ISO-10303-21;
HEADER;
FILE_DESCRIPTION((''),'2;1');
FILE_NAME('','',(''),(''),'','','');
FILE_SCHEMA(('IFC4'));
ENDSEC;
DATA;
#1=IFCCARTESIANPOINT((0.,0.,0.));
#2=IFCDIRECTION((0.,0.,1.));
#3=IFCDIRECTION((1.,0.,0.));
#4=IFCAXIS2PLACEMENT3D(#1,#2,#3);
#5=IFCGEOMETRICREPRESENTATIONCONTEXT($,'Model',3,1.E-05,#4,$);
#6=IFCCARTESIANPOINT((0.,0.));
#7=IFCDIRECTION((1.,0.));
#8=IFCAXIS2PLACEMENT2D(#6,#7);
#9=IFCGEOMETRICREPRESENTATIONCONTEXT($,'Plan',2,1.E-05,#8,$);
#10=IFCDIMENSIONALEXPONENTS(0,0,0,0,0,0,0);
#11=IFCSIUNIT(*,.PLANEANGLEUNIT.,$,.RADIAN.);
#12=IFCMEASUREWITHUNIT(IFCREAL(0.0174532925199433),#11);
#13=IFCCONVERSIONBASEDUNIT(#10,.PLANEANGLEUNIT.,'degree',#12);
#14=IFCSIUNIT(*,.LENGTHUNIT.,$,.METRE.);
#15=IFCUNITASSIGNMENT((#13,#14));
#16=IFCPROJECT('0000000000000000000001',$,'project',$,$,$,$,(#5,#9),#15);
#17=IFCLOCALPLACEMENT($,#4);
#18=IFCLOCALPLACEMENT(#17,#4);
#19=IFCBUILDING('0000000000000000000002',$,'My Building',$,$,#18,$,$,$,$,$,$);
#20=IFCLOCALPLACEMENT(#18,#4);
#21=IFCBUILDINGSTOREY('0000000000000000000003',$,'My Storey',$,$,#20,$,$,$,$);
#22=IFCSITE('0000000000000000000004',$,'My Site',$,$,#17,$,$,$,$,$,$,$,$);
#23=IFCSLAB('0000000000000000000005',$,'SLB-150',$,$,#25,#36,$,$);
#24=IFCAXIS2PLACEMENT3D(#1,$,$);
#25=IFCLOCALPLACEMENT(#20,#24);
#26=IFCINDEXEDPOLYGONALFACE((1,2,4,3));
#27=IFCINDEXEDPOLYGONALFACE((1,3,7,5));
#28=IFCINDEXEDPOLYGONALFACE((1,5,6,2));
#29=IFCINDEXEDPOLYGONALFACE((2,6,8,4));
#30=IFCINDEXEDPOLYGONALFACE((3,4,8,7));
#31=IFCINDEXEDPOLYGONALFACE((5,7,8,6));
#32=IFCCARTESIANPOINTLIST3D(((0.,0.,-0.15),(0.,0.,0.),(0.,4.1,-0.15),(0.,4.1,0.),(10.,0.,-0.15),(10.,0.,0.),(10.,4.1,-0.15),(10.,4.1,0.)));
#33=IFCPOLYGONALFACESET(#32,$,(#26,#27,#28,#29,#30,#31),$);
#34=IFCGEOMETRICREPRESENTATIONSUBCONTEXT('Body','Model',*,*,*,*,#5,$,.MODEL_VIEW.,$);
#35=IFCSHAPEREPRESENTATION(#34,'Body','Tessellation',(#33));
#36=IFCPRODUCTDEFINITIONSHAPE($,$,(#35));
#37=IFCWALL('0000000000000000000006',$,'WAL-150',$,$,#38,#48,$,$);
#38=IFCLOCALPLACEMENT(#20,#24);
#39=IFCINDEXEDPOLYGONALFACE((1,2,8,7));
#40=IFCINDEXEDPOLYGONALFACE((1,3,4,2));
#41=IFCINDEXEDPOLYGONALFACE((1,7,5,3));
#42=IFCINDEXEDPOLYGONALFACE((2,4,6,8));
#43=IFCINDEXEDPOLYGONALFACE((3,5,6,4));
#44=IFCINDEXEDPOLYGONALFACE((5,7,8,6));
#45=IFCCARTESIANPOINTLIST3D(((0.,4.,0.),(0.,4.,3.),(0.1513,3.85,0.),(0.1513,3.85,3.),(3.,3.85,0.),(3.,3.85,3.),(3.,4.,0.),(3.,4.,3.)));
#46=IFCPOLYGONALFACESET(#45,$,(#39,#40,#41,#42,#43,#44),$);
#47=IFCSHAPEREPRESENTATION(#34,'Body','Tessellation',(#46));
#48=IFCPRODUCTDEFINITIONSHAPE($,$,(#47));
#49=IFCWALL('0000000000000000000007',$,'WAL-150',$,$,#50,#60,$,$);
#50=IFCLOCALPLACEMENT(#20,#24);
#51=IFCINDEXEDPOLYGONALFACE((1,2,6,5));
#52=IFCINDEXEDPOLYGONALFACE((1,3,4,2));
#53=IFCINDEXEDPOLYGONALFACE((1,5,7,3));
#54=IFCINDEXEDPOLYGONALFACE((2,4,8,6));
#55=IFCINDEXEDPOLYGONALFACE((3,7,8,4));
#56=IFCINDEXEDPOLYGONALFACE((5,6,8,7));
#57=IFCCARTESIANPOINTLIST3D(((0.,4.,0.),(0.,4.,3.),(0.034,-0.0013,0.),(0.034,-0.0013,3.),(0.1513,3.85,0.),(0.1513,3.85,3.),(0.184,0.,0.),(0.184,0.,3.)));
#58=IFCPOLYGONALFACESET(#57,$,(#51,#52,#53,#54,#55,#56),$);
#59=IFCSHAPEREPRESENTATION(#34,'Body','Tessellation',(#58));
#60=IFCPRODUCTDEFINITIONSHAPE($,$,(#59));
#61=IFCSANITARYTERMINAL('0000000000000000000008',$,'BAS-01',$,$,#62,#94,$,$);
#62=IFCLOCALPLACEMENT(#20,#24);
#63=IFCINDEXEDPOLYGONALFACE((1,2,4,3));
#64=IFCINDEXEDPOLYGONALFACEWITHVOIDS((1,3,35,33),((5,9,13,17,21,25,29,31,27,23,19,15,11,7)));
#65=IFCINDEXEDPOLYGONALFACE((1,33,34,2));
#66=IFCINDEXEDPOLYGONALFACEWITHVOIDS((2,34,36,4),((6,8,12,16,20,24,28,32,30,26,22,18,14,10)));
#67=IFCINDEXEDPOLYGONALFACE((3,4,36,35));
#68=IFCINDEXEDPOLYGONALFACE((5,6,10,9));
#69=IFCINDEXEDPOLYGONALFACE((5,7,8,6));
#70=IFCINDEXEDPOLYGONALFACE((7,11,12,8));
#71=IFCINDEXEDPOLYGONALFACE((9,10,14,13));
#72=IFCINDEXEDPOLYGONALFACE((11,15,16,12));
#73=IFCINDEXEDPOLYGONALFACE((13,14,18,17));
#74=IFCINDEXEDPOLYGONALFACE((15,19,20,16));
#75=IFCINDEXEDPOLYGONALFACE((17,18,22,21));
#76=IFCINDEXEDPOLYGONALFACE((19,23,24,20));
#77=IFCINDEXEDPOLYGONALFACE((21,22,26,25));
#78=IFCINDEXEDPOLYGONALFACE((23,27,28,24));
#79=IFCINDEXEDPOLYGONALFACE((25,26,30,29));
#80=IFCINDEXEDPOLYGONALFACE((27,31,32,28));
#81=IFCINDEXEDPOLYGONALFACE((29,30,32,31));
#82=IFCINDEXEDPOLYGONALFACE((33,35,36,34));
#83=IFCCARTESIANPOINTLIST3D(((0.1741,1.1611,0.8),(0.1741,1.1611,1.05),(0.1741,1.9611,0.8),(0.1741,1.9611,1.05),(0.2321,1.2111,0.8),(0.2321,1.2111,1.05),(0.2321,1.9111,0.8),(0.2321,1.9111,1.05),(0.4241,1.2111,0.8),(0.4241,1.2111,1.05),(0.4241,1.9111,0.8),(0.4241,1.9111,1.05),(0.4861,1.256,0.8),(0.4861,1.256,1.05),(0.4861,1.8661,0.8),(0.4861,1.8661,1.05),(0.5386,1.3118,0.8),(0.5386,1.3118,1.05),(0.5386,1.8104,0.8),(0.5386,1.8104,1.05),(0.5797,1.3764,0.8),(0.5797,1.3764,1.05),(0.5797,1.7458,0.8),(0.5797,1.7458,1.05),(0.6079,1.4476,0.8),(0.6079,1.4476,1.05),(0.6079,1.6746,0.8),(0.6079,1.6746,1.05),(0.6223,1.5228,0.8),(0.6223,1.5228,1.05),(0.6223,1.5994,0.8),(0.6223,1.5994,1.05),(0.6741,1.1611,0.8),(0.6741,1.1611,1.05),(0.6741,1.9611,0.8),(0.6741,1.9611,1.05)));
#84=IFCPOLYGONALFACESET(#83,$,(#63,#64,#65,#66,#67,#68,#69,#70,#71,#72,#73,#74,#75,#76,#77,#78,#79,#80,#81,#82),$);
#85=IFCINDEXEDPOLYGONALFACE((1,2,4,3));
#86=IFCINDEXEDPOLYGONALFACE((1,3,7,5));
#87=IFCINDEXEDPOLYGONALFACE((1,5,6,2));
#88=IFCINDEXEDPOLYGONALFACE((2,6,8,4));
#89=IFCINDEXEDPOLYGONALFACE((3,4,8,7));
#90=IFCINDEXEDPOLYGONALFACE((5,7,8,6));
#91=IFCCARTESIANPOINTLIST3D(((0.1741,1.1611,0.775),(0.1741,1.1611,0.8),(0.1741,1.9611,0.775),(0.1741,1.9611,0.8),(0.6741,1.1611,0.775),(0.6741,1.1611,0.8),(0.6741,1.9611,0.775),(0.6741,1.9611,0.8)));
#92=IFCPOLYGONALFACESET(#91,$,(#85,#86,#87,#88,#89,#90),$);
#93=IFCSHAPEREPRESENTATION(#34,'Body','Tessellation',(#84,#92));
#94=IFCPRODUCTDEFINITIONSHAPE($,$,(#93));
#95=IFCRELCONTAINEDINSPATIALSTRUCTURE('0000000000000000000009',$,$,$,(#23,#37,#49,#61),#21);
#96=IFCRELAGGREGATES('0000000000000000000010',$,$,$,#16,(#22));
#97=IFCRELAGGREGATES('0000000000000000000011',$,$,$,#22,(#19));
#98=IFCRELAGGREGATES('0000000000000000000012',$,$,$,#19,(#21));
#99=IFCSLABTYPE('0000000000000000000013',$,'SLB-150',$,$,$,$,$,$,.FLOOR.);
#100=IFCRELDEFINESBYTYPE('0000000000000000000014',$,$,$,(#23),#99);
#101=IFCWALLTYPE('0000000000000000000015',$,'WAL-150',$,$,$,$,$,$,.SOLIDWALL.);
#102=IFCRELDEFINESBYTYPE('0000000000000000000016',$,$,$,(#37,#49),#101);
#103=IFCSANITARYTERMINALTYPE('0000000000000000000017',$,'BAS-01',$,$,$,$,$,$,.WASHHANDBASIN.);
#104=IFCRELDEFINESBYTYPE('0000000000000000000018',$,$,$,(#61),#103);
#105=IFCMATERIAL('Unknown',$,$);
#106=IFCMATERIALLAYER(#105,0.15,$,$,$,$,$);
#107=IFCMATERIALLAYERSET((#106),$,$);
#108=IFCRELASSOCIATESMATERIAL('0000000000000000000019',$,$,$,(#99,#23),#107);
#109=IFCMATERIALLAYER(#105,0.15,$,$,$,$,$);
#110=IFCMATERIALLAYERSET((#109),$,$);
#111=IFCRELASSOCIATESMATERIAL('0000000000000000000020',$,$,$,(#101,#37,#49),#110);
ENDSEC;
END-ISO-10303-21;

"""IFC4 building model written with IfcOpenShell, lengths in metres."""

from ifc_helpers import new_model, entity, si_unit, converted_unit, frame, origin_with_axes, origin_2d_with_axis, place, context, subcontext, project, spatial, line, arc, indexed_curve, outline, extrude, source, transform, mapped, material, layer, layer_set, layer_usage, type_object, type_shapes, element, save


model = new_model("IFC4")

# Units and contexts
model_context = context("Model", 3, precision=1e-05, world=origin_with_axes())
plan_context = context("Plan", 2, precision=1e-05, world=origin_2d_with_axis())
body_context = subcontext(model_context, "Body", "Model", "MODEL_VIEW")
ifc_project = project(units=[converted_unit("PLANEANGLEUNIT", "degree", entity("IfcReal", 0.0174532925199433), si_unit("PLANEANGLEUNIT", "RADIAN"), dimensions=[0, 0, 0, 0, 0, 0, 0]), si_unit("LENGTHUNIT", "METRE")], contexts=[model_context, plan_context])

# Site, building, storey
site_placement = place(None, origin_with_axes())
site = spatial("IfcSite", under=ifc_project, at=site_placement, Name="My Site")
building_placement = place(site_placement, origin_with_axes())
building = spatial("IfcBuilding", under=site, at=building_placement, Name="My Building")
storey_placement = place(building_placement, origin_with_axes())
storey = spatial("IfcBuildingStorey", under=building, at=storey_placement, Name="My Storey")

# Slab
ifc_material_1 = material(Name="Unknown")
ifc_layer_1 = layer(ifc_material_1, 0.15)
ifc_layer_set_1 = layer_set([ifc_layer_1])
ifc_layer_usage_1 = layer_usage(ifc_layer_set_1, "AXIS3", "POSITIVE", -0.15)
slab_type = type_object("IfcSlabType", Name="SLB-150", PredefinedType="FLOOR", material=ifc_layer_set_1)
slab_placement = place(storey_placement, origin_with_axes())
element("IfcSlab", 1, at=slab_placement, inside=storey, type_object=slab_type, material=ifc_layer_usage_1, Name="SLB-150", context=body_context, shape_type="SweptSolid", body=[
    extrude(outline(indexed_curve([(0.0, 0.0), (0.0, 4.1), (10.0, 4.1), (10.0, 0.0), (0.0, 0.0)])), frame((0.0, 0.0, -0.15), z_axis=(0.0, 0.0, 1.0), x_axis=(1.0, 0.0, 0.0)), (0.0, 0.0, 1.0), 0.15),
])

# Walls
ifc_layer_2 = layer(ifc_material_1, 0.15)
ifc_layer_set_2 = layer_set([ifc_layer_2])
ifc_layer_usage_2 = layer_usage(ifc_layer_set_2, "AXIS2", "POSITIVE", 0.0)
wall_type = type_object("IfcWallType", Name="WAL-150", PredefinedType="SOLIDWALL", material=ifc_layer_set_2)
wall_1_placement = place(storey_placement, frame((0.1513, 3.85, 0.0), z_axis=(0.0, 0.0, 1.0), x_axis=(1.0, 0.0, 0.0)))
element("IfcWall", 2, at=wall_1_placement, inside=storey, type_object=wall_type, material=ifc_layer_usage_2, Name="WAL-150", context=body_context, shape_type="SweptSolid", body=[
    extrude(outline(indexed_curve([(0.0, 0.0), (-0.1513, 0.15), (2.8487, 0.15), (2.8487, 0.0)], segments=[line(1, 2, 3, 4, 1)])), origin_with_axes(), (0.0, 0.0, 1.0), 3.0),
])
ifc_layer_usage_3 = layer_usage(ifc_layer_set_2, "AXIS2", "POSITIVE", 0.0)
wall_2_placement = place(storey_placement, frame((0.184, 0.0, 0.0), z_axis=(0.0, 0.0, 1.0), x_axis=(-0.008496, 0.999964, 0.0)))
element("IfcWall", 3, at=wall_2_placement, inside=storey, type_object=wall_type, material=ifc_layer_usage_3, Name="WAL-150", context=body_context, shape_type="SweptSolid", body=[
    extrude(outline(indexed_curve([(0.0, 0.0), (0.0, 0.15), (4.0014, 0.15), (3.8501, 0.0)], segments=[line(1, 2, 3, 4, 1)])), origin_with_axes(), (0.0, 0.0, 1.0), 3.0),
])

# Sanitary terminal
sanitary_terminal_type = type_object("IfcSanitaryTerminalType", Name="BAS-01", PredefinedType="WASHHANDBASIN")
shared_shape_1 = source(origin_with_axes(), body_context, "Body", "SweptSolid", [
    extrude(outline(indexed_curve([(0.0, 0.0), (0.5, 0.0), (0.5, 0.8), (0.0, 0.8), (0.0, 0.0)]), holes=[indexed_curve([(0.058, 0.75), (0.058, 0.05), (0.25, 0.05), (0.45, 0.4), (0.25, 0.75)], segments=[line(1, 2), line(2, 3), arc(3, 4, 5), line(5, 1)])]), origin_with_axes(), (0.0, 0.0, 1.0), 0.25),
    extrude(outline(indexed_curve([(0.0, 0.8), (0.5, 0.8), (0.5, 0.0), (0.0, 0.0), (0.0, 0.8)])), frame((0.0, 0.0, -0.025), z_axis=(0.0, 0.0, 1.0), x_axis=(1.0, 0.0, 0.0)), (0.0, 0.0, 1.0), 0.025),
])
type_shapes(sanitary_terminal_type, [shared_shape_1])
sanitary_terminal_placement = place(storey_placement, frame((0.1741, 1.1611, 0.8), z_axis=(0.0, 0.0, 1.0), x_axis=(1.0, 0.0, 0.0)))
element("IfcSanitaryTerminal", 4, at=sanitary_terminal_placement, inside=storey, type_object=sanitary_terminal_type, Name="BAS-01", context=body_context, shape_type="MappedRepresentation", body=[
    mapped(shared_shape_1, transform((0.0, 0.0, 0.0), x_axis=(1.0, 0.0, 0.0), y_axis=(0.0, 1.0, 0.0), z_axis=(0.0, 0.0, 1.0), scale=1.0)),
])

save(model, "model.ifc")
